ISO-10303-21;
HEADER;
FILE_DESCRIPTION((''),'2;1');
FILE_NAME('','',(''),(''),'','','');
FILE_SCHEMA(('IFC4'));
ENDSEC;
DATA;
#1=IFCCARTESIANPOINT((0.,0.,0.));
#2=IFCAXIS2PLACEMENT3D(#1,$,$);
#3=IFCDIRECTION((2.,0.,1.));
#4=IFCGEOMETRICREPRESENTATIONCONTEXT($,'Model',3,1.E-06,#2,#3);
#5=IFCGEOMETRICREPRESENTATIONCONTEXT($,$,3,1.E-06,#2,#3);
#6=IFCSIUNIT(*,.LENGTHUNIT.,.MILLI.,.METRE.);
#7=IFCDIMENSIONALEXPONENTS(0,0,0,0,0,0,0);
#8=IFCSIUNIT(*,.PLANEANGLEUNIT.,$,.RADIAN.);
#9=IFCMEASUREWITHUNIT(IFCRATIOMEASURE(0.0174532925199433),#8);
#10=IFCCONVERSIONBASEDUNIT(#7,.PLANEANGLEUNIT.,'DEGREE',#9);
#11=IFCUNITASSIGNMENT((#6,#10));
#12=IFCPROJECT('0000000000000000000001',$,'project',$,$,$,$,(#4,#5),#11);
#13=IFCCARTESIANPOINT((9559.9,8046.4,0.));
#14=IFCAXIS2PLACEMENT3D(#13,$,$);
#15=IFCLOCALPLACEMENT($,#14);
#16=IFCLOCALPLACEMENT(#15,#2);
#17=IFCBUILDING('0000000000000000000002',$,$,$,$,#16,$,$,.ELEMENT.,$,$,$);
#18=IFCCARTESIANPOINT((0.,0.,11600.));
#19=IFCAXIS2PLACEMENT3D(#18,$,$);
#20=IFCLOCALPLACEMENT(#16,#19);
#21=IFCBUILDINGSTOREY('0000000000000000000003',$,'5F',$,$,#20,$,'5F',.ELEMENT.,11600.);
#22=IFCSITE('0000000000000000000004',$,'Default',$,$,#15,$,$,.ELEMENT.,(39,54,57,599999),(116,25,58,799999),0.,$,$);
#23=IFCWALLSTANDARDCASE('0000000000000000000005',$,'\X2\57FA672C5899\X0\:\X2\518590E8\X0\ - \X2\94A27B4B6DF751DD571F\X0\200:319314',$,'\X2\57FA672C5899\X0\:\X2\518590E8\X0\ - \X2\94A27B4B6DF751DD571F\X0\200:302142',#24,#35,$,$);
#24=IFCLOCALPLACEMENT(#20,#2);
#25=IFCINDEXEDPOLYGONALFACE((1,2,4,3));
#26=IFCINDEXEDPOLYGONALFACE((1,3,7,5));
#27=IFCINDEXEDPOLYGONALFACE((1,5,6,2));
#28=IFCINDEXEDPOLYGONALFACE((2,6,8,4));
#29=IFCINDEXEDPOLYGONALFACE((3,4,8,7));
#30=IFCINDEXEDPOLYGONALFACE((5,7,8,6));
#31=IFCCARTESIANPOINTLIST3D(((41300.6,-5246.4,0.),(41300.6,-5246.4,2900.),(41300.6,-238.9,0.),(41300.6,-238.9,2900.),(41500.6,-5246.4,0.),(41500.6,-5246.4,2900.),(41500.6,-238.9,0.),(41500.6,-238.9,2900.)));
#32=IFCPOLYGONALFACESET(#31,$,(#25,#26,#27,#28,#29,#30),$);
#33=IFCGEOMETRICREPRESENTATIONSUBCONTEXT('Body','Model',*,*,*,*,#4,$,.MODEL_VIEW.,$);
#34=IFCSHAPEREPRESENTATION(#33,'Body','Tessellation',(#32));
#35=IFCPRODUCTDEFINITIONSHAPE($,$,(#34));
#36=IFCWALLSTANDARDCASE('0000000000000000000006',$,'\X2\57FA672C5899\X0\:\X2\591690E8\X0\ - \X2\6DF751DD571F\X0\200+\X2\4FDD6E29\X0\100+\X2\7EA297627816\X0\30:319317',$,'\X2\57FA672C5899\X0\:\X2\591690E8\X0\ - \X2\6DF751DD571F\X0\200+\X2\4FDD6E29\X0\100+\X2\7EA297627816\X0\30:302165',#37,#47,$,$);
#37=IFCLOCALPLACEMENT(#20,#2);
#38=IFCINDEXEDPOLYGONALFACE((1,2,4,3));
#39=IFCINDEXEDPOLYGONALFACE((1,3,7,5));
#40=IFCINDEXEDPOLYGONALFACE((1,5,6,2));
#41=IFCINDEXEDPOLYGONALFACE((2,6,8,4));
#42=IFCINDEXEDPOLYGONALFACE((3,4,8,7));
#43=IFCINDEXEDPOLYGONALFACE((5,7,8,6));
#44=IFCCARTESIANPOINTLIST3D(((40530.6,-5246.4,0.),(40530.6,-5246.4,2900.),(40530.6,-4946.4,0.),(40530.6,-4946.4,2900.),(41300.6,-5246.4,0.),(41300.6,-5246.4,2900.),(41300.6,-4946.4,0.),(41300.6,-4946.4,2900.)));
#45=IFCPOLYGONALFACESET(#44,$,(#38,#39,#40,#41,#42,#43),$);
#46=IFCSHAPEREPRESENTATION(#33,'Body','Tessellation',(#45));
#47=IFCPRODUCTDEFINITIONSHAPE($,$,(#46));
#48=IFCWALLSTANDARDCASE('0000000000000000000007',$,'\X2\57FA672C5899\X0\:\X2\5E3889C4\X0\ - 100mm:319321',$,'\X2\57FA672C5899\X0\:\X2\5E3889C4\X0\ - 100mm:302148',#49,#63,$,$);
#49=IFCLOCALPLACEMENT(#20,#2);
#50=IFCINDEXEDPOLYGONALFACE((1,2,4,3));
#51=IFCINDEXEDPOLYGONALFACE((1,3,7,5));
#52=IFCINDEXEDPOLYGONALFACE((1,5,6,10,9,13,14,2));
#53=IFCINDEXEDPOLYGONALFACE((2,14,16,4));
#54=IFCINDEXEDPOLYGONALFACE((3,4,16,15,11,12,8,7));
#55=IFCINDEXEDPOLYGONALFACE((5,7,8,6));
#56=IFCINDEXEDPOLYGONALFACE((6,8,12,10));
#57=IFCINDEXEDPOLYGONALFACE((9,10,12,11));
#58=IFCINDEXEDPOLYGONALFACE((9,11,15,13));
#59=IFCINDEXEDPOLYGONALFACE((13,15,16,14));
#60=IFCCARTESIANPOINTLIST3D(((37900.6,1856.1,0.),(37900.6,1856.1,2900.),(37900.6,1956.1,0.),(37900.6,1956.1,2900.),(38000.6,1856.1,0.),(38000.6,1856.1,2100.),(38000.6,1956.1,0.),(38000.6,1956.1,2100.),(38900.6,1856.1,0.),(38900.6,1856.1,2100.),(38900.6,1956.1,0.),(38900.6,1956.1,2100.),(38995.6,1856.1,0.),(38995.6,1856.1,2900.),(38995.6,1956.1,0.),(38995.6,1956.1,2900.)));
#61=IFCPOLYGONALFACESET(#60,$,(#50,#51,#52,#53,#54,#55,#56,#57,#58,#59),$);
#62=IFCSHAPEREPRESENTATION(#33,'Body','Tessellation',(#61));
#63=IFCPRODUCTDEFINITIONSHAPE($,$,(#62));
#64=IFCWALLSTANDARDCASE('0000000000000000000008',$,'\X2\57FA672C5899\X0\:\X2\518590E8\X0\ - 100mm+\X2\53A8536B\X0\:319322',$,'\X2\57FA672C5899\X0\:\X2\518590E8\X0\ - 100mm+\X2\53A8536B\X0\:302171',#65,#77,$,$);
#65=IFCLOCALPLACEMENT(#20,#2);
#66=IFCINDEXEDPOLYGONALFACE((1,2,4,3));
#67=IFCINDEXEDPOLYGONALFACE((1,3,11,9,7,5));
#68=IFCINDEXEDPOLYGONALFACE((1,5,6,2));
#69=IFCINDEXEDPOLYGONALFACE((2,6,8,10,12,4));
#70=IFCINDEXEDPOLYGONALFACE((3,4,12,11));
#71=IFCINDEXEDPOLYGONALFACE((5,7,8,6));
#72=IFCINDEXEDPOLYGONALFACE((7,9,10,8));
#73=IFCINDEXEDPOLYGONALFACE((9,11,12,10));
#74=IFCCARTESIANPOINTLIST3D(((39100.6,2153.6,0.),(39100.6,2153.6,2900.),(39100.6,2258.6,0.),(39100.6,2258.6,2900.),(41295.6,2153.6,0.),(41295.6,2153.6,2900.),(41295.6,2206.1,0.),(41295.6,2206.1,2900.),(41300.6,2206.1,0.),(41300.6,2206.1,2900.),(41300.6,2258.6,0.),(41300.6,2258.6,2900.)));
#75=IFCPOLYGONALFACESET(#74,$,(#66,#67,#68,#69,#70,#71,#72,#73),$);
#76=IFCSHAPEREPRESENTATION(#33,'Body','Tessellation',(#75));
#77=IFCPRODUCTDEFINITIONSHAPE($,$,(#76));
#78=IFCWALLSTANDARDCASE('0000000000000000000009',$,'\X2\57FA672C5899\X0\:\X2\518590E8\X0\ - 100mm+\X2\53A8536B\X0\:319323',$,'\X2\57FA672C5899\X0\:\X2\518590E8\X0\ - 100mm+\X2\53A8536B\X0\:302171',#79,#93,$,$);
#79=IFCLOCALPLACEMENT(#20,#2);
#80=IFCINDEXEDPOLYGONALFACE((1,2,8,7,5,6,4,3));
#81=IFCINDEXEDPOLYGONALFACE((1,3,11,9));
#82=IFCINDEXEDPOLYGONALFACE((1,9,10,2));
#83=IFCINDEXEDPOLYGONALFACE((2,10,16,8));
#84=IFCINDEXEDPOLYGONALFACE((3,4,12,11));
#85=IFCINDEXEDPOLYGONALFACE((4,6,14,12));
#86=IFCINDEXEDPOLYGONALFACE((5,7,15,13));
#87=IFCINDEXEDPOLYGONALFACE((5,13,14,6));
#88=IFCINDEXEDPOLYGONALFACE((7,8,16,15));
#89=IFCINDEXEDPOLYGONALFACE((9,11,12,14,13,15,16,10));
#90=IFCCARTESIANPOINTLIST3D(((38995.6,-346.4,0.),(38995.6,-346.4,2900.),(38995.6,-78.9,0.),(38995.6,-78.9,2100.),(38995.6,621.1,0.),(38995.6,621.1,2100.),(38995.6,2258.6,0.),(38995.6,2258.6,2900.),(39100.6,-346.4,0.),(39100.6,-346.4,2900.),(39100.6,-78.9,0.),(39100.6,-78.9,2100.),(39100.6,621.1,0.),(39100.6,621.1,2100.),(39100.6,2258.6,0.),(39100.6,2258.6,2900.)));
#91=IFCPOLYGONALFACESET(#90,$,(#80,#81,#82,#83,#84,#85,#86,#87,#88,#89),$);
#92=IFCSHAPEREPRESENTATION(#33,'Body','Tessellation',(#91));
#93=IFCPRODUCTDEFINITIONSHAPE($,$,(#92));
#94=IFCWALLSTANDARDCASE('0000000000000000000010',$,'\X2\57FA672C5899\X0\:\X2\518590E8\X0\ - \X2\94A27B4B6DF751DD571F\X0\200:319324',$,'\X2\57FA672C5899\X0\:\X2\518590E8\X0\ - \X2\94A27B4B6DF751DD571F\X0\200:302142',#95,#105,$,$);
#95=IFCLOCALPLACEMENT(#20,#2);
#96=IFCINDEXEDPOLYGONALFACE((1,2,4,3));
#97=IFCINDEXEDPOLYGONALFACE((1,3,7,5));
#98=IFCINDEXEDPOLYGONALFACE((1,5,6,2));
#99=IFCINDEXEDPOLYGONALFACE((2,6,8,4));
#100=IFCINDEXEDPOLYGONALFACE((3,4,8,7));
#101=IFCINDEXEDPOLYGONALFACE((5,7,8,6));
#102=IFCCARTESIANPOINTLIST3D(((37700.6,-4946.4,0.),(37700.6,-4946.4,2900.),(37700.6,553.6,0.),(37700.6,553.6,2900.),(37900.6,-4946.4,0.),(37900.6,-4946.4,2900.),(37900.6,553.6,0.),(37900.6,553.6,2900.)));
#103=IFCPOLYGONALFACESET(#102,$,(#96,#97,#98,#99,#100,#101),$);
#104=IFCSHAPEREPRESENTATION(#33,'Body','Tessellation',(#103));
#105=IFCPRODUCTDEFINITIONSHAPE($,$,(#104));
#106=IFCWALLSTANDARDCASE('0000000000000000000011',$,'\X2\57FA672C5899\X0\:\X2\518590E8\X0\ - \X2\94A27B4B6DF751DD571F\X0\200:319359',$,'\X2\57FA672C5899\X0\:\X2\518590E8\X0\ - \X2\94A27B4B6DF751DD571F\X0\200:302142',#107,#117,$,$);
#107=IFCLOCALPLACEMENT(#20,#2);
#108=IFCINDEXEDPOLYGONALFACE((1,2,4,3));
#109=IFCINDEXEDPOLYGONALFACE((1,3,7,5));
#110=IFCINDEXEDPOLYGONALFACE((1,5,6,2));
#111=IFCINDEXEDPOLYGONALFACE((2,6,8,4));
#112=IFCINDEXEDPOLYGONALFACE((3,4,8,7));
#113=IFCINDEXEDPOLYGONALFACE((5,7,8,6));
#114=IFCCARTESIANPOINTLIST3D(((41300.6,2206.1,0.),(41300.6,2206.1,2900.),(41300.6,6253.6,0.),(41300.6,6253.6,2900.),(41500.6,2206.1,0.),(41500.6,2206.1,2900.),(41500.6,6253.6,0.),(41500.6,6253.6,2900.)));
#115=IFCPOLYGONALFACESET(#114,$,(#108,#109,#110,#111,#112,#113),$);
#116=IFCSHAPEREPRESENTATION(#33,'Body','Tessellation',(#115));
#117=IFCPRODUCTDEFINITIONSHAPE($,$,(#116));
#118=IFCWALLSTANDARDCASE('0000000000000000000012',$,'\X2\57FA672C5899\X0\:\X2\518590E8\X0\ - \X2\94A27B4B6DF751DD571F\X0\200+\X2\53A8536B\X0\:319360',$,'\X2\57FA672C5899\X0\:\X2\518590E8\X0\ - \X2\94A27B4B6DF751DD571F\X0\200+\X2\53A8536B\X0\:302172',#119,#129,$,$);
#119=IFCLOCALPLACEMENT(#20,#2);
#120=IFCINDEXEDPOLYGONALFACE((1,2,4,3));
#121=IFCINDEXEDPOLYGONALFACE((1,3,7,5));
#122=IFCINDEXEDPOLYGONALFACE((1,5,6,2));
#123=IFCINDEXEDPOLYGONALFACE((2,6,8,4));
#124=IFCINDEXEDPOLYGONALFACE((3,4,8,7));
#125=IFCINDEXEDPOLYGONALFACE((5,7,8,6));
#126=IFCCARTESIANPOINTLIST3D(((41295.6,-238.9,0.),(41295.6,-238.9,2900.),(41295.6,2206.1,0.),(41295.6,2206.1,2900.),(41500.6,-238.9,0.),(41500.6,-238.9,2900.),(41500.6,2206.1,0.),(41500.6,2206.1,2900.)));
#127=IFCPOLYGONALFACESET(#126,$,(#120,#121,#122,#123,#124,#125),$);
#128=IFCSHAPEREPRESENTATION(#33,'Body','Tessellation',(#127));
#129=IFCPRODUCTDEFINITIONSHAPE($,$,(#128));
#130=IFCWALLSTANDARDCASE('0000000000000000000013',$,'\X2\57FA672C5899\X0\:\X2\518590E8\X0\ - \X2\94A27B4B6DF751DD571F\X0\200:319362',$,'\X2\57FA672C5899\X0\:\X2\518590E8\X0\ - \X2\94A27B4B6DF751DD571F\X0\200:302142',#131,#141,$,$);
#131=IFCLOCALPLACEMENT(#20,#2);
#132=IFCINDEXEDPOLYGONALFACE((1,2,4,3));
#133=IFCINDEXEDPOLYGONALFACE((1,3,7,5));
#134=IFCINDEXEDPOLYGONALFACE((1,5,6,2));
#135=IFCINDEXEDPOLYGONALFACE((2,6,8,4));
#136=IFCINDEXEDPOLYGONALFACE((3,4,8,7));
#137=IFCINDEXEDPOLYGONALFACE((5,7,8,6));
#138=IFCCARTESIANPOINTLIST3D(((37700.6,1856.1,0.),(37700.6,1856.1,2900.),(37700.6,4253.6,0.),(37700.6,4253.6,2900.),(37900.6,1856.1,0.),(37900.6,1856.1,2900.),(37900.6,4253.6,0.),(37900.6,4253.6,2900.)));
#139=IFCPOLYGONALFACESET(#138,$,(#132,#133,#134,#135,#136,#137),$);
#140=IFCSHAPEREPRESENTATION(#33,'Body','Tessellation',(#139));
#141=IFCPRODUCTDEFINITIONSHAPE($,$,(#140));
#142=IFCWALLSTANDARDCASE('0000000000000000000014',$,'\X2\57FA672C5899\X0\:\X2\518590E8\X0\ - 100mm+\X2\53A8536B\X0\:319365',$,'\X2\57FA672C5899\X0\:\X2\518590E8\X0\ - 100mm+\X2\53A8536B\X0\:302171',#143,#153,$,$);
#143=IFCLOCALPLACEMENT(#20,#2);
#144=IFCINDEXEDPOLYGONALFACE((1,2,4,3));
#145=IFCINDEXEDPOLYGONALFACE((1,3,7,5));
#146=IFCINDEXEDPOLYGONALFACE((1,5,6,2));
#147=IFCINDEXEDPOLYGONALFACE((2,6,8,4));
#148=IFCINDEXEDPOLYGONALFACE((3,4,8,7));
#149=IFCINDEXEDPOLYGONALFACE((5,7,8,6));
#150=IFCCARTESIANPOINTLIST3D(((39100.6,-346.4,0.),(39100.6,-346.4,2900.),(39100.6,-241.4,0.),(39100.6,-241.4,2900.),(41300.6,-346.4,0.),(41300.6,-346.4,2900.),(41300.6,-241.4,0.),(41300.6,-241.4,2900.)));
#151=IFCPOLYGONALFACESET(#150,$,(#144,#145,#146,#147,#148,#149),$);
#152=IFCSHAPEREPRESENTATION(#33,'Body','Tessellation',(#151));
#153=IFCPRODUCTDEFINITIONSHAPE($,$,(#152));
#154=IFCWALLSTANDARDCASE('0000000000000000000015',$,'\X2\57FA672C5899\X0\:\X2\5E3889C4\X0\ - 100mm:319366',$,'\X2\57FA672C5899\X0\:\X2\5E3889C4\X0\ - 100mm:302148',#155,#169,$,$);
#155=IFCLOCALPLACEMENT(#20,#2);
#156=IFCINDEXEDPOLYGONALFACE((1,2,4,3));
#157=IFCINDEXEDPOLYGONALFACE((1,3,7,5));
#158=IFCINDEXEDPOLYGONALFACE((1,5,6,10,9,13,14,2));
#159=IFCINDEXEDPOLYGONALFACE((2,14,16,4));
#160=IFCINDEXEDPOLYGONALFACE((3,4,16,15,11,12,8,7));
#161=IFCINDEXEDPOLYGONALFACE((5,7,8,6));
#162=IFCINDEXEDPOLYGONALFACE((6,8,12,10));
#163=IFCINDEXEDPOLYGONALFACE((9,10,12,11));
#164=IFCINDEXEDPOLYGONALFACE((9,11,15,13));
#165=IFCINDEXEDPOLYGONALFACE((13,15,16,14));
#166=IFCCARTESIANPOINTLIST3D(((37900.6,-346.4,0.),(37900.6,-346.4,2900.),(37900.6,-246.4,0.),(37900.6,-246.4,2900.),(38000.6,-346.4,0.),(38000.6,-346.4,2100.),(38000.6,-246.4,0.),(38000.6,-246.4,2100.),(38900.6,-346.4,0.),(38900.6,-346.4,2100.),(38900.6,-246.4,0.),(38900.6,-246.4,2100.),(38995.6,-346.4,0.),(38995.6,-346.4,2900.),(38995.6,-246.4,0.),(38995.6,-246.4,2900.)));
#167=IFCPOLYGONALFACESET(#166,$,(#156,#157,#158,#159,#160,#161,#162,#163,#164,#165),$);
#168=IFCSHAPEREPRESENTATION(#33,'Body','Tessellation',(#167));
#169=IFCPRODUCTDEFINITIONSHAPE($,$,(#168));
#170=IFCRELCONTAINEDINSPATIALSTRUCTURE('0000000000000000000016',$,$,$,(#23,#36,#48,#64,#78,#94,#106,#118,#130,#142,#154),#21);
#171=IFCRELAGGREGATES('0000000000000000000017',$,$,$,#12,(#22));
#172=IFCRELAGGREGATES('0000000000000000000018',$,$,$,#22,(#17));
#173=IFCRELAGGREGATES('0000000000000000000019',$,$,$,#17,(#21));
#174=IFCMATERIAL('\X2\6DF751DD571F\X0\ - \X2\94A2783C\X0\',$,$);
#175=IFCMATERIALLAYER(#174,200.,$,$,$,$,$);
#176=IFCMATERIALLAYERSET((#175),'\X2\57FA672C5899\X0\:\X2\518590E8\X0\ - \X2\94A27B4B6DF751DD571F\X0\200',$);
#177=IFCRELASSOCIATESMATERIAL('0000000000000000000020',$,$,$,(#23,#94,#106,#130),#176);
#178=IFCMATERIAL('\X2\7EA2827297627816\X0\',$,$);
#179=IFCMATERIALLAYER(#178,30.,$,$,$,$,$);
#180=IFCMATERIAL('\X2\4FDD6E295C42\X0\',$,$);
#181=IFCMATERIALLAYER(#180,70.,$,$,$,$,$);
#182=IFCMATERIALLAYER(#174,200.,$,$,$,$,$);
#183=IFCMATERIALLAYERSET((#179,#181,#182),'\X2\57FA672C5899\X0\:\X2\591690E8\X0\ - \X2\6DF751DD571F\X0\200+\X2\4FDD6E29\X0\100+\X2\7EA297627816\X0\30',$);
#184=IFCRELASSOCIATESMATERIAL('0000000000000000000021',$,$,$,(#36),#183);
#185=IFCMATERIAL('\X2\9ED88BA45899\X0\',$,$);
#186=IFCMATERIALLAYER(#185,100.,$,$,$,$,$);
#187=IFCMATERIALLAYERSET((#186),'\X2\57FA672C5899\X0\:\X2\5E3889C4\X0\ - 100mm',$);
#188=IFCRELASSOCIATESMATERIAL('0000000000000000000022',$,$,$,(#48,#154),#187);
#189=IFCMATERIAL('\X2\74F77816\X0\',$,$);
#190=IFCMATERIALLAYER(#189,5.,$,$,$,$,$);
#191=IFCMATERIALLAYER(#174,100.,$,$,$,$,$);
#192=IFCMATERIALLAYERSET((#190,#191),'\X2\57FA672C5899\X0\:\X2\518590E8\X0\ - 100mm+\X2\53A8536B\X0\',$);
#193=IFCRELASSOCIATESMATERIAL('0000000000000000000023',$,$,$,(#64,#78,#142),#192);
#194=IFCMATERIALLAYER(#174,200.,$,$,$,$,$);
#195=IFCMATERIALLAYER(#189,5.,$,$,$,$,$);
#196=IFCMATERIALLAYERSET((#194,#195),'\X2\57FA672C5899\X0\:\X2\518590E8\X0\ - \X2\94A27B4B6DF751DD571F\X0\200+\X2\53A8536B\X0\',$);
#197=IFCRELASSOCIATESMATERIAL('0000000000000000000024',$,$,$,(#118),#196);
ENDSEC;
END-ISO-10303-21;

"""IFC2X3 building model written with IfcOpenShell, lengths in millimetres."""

from ifc_helpers import new_model, entity, si_unit, converted_unit, direction, frame, frame_2d, origin, place, context, subcontext, project, spatial, polyline, rectangle, outline, extrude, material, layer, layer_set, layer_usage, element, save


model = new_model("IFC2X3")

# Units and contexts
model_context = context("Model", 3, precision=1e-06, world=origin(), true_north=direction((2.0, 0.0, 1.0)))
context_of_model = context(None, 3, precision=1e-06, world=origin(), true_north=direction((2.0, 0.0, 1.0)))
body_context = subcontext(model_context, "Body", "Model", "MODEL_VIEW")
ifc_project = project(units=[si_unit("LENGTHUNIT", "METRE", prefix="MILLI"), converted_unit("PLANEANGLEUNIT", "DEGREE", entity("IfcRatioMeasure", 0.0174532925199433), si_unit("PLANEANGLEUNIT", "RADIAN"), dimensions=[0, 0, 0, 0, 0, 0, 0])], contexts=[model_context, context_of_model])

# Site, building, storey
site_placement = place(None, frame((9559.9, 8046.4, 0.0)))
site = spatial("IfcSite", under=ifc_project, at=site_placement, Name="Default", CompositionType="ELEMENT", RefLatitude=(39, 54, 57, 599999), RefLongitude=(116, 25, 58, 799999), RefElevation=0.0)
building_placement = place(site_placement, origin())
building = spatial("IfcBuilding", under=site, at=building_placement, CompositionType="ELEMENT")
storey_placement = place(building_placement, frame((0.0, 0.0, 11600.0)))
storey = spatial("IfcBuildingStorey", under=building, at=storey_placement, Name="5F", LongName="5F", CompositionType="ELEMENT", Elevation=11600.0)

# Walls
ifc_material_1 = material(Name="混凝土 - 钢砼")
ifc_layer_1 = layer(ifc_material_1, 200.0)
ifc_layer_set_1 = layer_set([ifc_layer_1], Name="基本墙:内部 - 钢筋混凝土200")
ifc_layer_usage_1 = layer_usage(ifc_layer_set_1, "AXIS2", "POSITIVE", -100.0)
wall_1_placement = place(storey_placement, frame((41400.6, -5246.4, 0.0), z_axis=(0.0, 0.0, 1.0), x_axis=(0.0, 1.0, 0.0)))
element("IfcWallStandardCase", 1, at=wall_1_placement, inside=storey, material=ifc_layer_usage_1, Name="基本墙:内部 - 钢筋混凝土200:319314", ObjectType="基本墙:内部 - 钢筋混凝土200:302142", context=body_context, shape_type="SweptSolid", body=[
    extrude(rectangle(XDim=5007.5, YDim=200.0, at=frame_2d((2503.8, 0.0), x_axis=(-1.0, 0.0))), origin(), (0.0, 0.0, 1.0), 2900.0),
])
ifc_material_2 = material(Name="红色面砖")
ifc_layer_2 = layer(ifc_material_2, 30.0)
ifc_material_3 = material(Name="保温层")
ifc_layer_3 = layer(ifc_material_3, 70.0)
ifc_layer_4 = layer(ifc_material_1, 200.0)
ifc_layer_set_2 = layer_set([ifc_layer_2, ifc_layer_3, ifc_layer_4], Name="基本墙:外部 - 混凝土200+保温100+红面砖30")
ifc_layer_usage_2 = layer_usage(ifc_layer_set_2, "AXIS2", "NEGATIVE", 150.0)
wall_2_placement = place(storey_placement, frame((41300.6, -5096.4, 0.0), z_axis=(0.0, 0.0, 1.0), x_axis=(-1.0, 0.0, 0.0)))
element("IfcWallStandardCase", 2, at=wall_2_placement, inside=storey, material=ifc_layer_usage_2, Name="基本墙:外部 - 混凝土200+保温100+红面砖30:319317", ObjectType="基本墙:外部 - 混凝土200+保温100+红面砖30:302165", context=body_context, shape_type="SweptSolid", body=[
    extrude(rectangle(XDim=770.0, YDim=300.0, at=frame_2d((385.0, 0.0), x_axis=(-1.0, 0.0))), origin(), (0.0, 0.0, 1.0), 2900.0),
])

# Wall, opening
ifc_material_4 = material(Name="默认墙")
ifc_layer_5 = layer(ifc_material_4, 100.0)
ifc_layer_set_3 = layer_set([ifc_layer_5], Name="基本墙:常规 - 100mm")
ifc_layer_usage_3 = layer_usage(ifc_layer_set_3, "AXIS2", "POSITIVE", -50.0)
wall_3_placement = place(storey_placement, frame((38995.6, 1906.1, 0.0), z_axis=(0.0, 0.0, 1.0), x_axis=(-1.0, 0.0, 0.0)))
wall_3 = element("IfcWallStandardCase", 3, at=wall_3_placement, inside=storey, material=ifc_layer_usage_3, Name="基本墙:常规 - 100mm:319321", ObjectType="基本墙:常规 - 100mm:302148", context=body_context, shape_type="SweptSolid", body=[
    extrude(rectangle(XDim=1095.0, YDim=100.0, at=frame_2d((547.5, 0.0), x_axis=(-1.0, 0.0))), origin(), (0.0, 0.0, 1.0), 2900.0),
])
opening_1_placement = place(wall_3_placement, frame((995.0, 50.0, 0.0)))
element("IfcOpeningElement", 4, at=opening_1_placement, cuts=wall_3, ObjectType="Opening", context=body_context, shape_type="SweptSolid", body=[
    extrude(rectangle(XDim=2100.0, YDim=900.0, at=frame_2d((1050.0, 450.0), x_axis=(1.0, 0.0))), frame((0.0, 0.0, 0.0), z_axis=(0.0, -1.0, 0.0), x_axis=(0.0, 0.0, 1.0)), (0.0, 0.0, 1.0), 100.0),
])

# Wall
ifc_material_5 = material(Name="瓷砖")
ifc_layer_6 = layer(ifc_material_5, 5.0)
ifc_layer_7 = layer(ifc_material_1, 100.0)
ifc_layer_set_4 = layer_set([ifc_layer_6, ifc_layer_7], Name="基本墙:内部 - 100mm+厨卫")
ifc_layer_usage_4 = layer_usage(ifc_layer_set_4, "AXIS2", "NEGATIVE", 52.5)
wall_4_placement = place(storey_placement, frame((41300.6, 2206.1, 0.0), z_axis=(0.0, 0.0, 1.0), x_axis=(-1.0, 0.0, 0.0)))
element("IfcWallStandardCase", 5, at=wall_4_placement, inside=storey, material=ifc_layer_usage_4, Name="基本墙:内部 - 100mm+厨卫:319322", ObjectType="基本墙:内部 - 100mm+厨卫:302171", context=body_context, shape_type="SweptSolid", body=[
    extrude(outline(polyline([(2200.0, -52.5), (2200.0, 52.5), (5.0, 52.5), (5.0, 0.0), (0.0, 0.0), (0.0, -52.5), (2200.0, -52.5)])), origin(), (0.0, 0.0, 1.0), 2900.0),
])

# Wall, opening
ifc_layer_usage_5 = layer_usage(ifc_layer_set_4, "AXIS2", "NEGATIVE", 52.5)
wall_5_placement = place(storey_placement, frame((39048.1, 2258.6, 0.0), z_axis=(0.0, 0.0, 1.0), x_axis=(0.0, -1.0, 0.0)))
wall_5 = element("IfcWallStandardCase", 6, at=wall_5_placement, inside=storey, material=ifc_layer_usage_5, Name="基本墙:内部 - 100mm+厨卫:319323", ObjectType="基本墙:内部 - 100mm+厨卫:302171", context=body_context, shape_type="SweptSolid", body=[
    extrude(rectangle(XDim=2605.0, YDim=105.0, at=frame_2d((1302.5, 0.0), x_axis=(-1.0, 0.0))), origin(), (0.0, 0.0, 1.0), 2900.0),
])
opening_2_placement = place(wall_5_placement, frame((1637.5, -52.5, 0.0)))
element("IfcOpeningElement", 7, at=opening_2_placement, cuts=wall_5, ObjectType="Opening", context=body_context, shape_type="SweptSolid", body=[
    extrude(rectangle(XDim=2100.0, YDim=700.0, at=frame_2d((1050.0, 350.0), x_axis=(1.0, 0.0))), frame((0.0, 0.0, 0.0), z_axis=(0.0, 1.0, 0.0), x_axis=(0.0, 0.0, 1.0)), (0.0, 0.0, 1.0), 105.0),
])

# Walls
ifc_layer_usage_6 = layer_usage(ifc_layer_set_1, "AXIS2", "NEGATIVE", 100.0)
wall_6_placement = place(storey_placement, frame((37800.6, 553.6, 0.0), z_axis=(0.0, 0.0, 1.0), x_axis=(0.0, -1.0, 0.0)))
element("IfcWallStandardCase", 8, at=wall_6_placement, inside=storey, material=ifc_layer_usage_6, Name="基本墙:内部 - 钢筋混凝土200:319324", ObjectType="基本墙:内部 - 钢筋混凝土200:302142", context=body_context, shape_type="SweptSolid", body=[
    extrude(rectangle(XDim=5500.0, YDim=200.0, at=frame_2d((2750.0, 0.0), x_axis=(-1.0, 0.0))), origin(), (0.0, 0.0, 1.0), 2900.0),
])
ifc_layer_usage_7 = layer_usage(ifc_layer_set_1, "AXIS2", "POSITIVE", -100.0)
wall_7_placement = place(storey_placement, frame((41400.6, 2206.1, 0.0), z_axis=(0.0, 0.0, 1.0), x_axis=(0.0, 1.0, 0.0)))
element("IfcWallStandardCase", 9, at=wall_7_placement, inside=storey, material=ifc_layer_usage_7, Name="基本墙:内部 - 钢筋混凝土200:319359", ObjectType="基本墙:内部 - 钢筋混凝土200:302142", context=body_context, shape_type="SweptSolid", body=[
    extrude(rectangle(XDim=4047.5, YDim=200.0, at=frame_2d((2023.8, 0.0), x_axis=(-1.0, 0.0))), origin(), (0.0, 0.0, 1.0), 2900.0),
])
ifc_layer_8 = layer(ifc_material_1, 200.0)
ifc_layer_9 = layer(ifc_material_5, 5.0)
ifc_layer_set_5 = layer_set([ifc_layer_8, ifc_layer_9], Name="基本墙:内部 - 钢筋混凝土200+厨卫")
ifc_layer_usage_8 = layer_usage(ifc_layer_set_5, "AXIS2", "POSITIVE", -102.5)
wall_8_placement = place(storey_placement, frame((41398.1, -238.9, 0.0), z_axis=(0.0, 0.0, 1.0), x_axis=(0.0, 1.0, 0.0)))
element("IfcWallStandardCase", 10, at=wall_8_placement, inside=storey, material=ifc_layer_usage_8, Name="基本墙:内部 - 钢筋混凝土200+厨卫:319360", ObjectType="基本墙:内部 - 钢筋混凝土200+厨卫:302172", context=body_context, shape_type="SweptSolid", body=[
    extrude(rectangle(XDim=2445.0, YDim=205.0, at=frame_2d((1222.5, 0.0), x_axis=(-1.0, 0.0))), origin(), (0.0, 0.0, 1.0), 2900.0),
])
ifc_layer_usage_9 = layer_usage(ifc_layer_set_1, "AXIS2", "POSITIVE", -100.0)
wall_9_placement = place(storey_placement, frame((37800.6, 4253.6, 0.0), z_axis=(0.0, 0.0, 1.0), x_axis=(0.0, -1.0, 0.0)))
element("IfcWallStandardCase", 11, at=wall_9_placement, inside=storey, material=ifc_layer_usage_9, Name="基本墙:内部 - 钢筋混凝土200:319362", ObjectType="基本墙:内部 - 钢筋混凝土200:302142", context=body_context, shape_type="SweptSolid", body=[
    extrude(rectangle(XDim=2397.5, YDim=200.0, at=frame_2d((1198.8, 0.0), x_axis=(-1.0, 0.0))), origin(), (0.0, 0.0, 1.0), 2900.0),
])
ifc_layer_usage_10 = layer_usage(ifc_layer_set_4, "AXIS2", "POSITIVE", -52.5)
wall_10_placement = place(storey_placement, frame((41300.6, -293.9, 0.0), z_axis=(0.0, 0.0, 1.0), x_axis=(-1.0, 0.0, 0.0)))
element("IfcWallStandardCase", 12, at=wall_10_placement, inside=storey, material=ifc_layer_usage_10, Name="基本墙:内部 - 100mm+厨卫:319365", ObjectType="基本墙:内部 - 100mm+厨卫:302171", context=body_context, shape_type="SweptSolid", body=[
    extrude(rectangle(XDim=2200.0, YDim=105.0, at=frame_2d((1100.0, 0.0), x_axis=(-1.0, 0.0))), origin(), (0.0, 0.0, 1.0), 2900.0),
])

# Wall, opening
ifc_layer_usage_11 = layer_usage(ifc_layer_set_3, "AXIS2", "POSITIVE", -50.0)
wall_11_placement = place(storey_placement, frame((38995.6, -296.4, 0.0), z_axis=(0.0, 0.0, 1.0), x_axis=(-1.0, 0.0, 0.0)))
wall_11 = element("IfcWallStandardCase", 13, at=wall_11_placement, inside=storey, material=ifc_layer_usage_11, Name="基本墙:常规 - 100mm:319366", ObjectType="基本墙:常规 - 100mm:302148", context=body_context, shape_type="SweptSolid", body=[
    extrude(rectangle(XDim=1095.0, YDim=100.0, at=frame_2d((547.5, 0.0), x_axis=(-1.0, 0.0))), origin(), (0.0, 0.0, 1.0), 2900.0),
])
opening_3_placement = place(wall_11_placement, frame((95.0, -50.0, 0.0)))
element("IfcOpeningElement", 14, at=opening_3_placement, cuts=wall_11, ObjectType="Opening", context=body_context, shape_type="SweptSolid", body=[
    extrude(rectangle(XDim=2100.0, YDim=900.0, at=frame_2d((1050.0, 450.0), x_axis=(1.0, 0.0))), frame((0.0, 0.0, 0.0), z_axis=(0.0, 1.0, 0.0), x_axis=(0.0, 0.0, 1.0)), (0.0, 0.0, 1.0), 100.0),
])

save(model, "model.ifc")
